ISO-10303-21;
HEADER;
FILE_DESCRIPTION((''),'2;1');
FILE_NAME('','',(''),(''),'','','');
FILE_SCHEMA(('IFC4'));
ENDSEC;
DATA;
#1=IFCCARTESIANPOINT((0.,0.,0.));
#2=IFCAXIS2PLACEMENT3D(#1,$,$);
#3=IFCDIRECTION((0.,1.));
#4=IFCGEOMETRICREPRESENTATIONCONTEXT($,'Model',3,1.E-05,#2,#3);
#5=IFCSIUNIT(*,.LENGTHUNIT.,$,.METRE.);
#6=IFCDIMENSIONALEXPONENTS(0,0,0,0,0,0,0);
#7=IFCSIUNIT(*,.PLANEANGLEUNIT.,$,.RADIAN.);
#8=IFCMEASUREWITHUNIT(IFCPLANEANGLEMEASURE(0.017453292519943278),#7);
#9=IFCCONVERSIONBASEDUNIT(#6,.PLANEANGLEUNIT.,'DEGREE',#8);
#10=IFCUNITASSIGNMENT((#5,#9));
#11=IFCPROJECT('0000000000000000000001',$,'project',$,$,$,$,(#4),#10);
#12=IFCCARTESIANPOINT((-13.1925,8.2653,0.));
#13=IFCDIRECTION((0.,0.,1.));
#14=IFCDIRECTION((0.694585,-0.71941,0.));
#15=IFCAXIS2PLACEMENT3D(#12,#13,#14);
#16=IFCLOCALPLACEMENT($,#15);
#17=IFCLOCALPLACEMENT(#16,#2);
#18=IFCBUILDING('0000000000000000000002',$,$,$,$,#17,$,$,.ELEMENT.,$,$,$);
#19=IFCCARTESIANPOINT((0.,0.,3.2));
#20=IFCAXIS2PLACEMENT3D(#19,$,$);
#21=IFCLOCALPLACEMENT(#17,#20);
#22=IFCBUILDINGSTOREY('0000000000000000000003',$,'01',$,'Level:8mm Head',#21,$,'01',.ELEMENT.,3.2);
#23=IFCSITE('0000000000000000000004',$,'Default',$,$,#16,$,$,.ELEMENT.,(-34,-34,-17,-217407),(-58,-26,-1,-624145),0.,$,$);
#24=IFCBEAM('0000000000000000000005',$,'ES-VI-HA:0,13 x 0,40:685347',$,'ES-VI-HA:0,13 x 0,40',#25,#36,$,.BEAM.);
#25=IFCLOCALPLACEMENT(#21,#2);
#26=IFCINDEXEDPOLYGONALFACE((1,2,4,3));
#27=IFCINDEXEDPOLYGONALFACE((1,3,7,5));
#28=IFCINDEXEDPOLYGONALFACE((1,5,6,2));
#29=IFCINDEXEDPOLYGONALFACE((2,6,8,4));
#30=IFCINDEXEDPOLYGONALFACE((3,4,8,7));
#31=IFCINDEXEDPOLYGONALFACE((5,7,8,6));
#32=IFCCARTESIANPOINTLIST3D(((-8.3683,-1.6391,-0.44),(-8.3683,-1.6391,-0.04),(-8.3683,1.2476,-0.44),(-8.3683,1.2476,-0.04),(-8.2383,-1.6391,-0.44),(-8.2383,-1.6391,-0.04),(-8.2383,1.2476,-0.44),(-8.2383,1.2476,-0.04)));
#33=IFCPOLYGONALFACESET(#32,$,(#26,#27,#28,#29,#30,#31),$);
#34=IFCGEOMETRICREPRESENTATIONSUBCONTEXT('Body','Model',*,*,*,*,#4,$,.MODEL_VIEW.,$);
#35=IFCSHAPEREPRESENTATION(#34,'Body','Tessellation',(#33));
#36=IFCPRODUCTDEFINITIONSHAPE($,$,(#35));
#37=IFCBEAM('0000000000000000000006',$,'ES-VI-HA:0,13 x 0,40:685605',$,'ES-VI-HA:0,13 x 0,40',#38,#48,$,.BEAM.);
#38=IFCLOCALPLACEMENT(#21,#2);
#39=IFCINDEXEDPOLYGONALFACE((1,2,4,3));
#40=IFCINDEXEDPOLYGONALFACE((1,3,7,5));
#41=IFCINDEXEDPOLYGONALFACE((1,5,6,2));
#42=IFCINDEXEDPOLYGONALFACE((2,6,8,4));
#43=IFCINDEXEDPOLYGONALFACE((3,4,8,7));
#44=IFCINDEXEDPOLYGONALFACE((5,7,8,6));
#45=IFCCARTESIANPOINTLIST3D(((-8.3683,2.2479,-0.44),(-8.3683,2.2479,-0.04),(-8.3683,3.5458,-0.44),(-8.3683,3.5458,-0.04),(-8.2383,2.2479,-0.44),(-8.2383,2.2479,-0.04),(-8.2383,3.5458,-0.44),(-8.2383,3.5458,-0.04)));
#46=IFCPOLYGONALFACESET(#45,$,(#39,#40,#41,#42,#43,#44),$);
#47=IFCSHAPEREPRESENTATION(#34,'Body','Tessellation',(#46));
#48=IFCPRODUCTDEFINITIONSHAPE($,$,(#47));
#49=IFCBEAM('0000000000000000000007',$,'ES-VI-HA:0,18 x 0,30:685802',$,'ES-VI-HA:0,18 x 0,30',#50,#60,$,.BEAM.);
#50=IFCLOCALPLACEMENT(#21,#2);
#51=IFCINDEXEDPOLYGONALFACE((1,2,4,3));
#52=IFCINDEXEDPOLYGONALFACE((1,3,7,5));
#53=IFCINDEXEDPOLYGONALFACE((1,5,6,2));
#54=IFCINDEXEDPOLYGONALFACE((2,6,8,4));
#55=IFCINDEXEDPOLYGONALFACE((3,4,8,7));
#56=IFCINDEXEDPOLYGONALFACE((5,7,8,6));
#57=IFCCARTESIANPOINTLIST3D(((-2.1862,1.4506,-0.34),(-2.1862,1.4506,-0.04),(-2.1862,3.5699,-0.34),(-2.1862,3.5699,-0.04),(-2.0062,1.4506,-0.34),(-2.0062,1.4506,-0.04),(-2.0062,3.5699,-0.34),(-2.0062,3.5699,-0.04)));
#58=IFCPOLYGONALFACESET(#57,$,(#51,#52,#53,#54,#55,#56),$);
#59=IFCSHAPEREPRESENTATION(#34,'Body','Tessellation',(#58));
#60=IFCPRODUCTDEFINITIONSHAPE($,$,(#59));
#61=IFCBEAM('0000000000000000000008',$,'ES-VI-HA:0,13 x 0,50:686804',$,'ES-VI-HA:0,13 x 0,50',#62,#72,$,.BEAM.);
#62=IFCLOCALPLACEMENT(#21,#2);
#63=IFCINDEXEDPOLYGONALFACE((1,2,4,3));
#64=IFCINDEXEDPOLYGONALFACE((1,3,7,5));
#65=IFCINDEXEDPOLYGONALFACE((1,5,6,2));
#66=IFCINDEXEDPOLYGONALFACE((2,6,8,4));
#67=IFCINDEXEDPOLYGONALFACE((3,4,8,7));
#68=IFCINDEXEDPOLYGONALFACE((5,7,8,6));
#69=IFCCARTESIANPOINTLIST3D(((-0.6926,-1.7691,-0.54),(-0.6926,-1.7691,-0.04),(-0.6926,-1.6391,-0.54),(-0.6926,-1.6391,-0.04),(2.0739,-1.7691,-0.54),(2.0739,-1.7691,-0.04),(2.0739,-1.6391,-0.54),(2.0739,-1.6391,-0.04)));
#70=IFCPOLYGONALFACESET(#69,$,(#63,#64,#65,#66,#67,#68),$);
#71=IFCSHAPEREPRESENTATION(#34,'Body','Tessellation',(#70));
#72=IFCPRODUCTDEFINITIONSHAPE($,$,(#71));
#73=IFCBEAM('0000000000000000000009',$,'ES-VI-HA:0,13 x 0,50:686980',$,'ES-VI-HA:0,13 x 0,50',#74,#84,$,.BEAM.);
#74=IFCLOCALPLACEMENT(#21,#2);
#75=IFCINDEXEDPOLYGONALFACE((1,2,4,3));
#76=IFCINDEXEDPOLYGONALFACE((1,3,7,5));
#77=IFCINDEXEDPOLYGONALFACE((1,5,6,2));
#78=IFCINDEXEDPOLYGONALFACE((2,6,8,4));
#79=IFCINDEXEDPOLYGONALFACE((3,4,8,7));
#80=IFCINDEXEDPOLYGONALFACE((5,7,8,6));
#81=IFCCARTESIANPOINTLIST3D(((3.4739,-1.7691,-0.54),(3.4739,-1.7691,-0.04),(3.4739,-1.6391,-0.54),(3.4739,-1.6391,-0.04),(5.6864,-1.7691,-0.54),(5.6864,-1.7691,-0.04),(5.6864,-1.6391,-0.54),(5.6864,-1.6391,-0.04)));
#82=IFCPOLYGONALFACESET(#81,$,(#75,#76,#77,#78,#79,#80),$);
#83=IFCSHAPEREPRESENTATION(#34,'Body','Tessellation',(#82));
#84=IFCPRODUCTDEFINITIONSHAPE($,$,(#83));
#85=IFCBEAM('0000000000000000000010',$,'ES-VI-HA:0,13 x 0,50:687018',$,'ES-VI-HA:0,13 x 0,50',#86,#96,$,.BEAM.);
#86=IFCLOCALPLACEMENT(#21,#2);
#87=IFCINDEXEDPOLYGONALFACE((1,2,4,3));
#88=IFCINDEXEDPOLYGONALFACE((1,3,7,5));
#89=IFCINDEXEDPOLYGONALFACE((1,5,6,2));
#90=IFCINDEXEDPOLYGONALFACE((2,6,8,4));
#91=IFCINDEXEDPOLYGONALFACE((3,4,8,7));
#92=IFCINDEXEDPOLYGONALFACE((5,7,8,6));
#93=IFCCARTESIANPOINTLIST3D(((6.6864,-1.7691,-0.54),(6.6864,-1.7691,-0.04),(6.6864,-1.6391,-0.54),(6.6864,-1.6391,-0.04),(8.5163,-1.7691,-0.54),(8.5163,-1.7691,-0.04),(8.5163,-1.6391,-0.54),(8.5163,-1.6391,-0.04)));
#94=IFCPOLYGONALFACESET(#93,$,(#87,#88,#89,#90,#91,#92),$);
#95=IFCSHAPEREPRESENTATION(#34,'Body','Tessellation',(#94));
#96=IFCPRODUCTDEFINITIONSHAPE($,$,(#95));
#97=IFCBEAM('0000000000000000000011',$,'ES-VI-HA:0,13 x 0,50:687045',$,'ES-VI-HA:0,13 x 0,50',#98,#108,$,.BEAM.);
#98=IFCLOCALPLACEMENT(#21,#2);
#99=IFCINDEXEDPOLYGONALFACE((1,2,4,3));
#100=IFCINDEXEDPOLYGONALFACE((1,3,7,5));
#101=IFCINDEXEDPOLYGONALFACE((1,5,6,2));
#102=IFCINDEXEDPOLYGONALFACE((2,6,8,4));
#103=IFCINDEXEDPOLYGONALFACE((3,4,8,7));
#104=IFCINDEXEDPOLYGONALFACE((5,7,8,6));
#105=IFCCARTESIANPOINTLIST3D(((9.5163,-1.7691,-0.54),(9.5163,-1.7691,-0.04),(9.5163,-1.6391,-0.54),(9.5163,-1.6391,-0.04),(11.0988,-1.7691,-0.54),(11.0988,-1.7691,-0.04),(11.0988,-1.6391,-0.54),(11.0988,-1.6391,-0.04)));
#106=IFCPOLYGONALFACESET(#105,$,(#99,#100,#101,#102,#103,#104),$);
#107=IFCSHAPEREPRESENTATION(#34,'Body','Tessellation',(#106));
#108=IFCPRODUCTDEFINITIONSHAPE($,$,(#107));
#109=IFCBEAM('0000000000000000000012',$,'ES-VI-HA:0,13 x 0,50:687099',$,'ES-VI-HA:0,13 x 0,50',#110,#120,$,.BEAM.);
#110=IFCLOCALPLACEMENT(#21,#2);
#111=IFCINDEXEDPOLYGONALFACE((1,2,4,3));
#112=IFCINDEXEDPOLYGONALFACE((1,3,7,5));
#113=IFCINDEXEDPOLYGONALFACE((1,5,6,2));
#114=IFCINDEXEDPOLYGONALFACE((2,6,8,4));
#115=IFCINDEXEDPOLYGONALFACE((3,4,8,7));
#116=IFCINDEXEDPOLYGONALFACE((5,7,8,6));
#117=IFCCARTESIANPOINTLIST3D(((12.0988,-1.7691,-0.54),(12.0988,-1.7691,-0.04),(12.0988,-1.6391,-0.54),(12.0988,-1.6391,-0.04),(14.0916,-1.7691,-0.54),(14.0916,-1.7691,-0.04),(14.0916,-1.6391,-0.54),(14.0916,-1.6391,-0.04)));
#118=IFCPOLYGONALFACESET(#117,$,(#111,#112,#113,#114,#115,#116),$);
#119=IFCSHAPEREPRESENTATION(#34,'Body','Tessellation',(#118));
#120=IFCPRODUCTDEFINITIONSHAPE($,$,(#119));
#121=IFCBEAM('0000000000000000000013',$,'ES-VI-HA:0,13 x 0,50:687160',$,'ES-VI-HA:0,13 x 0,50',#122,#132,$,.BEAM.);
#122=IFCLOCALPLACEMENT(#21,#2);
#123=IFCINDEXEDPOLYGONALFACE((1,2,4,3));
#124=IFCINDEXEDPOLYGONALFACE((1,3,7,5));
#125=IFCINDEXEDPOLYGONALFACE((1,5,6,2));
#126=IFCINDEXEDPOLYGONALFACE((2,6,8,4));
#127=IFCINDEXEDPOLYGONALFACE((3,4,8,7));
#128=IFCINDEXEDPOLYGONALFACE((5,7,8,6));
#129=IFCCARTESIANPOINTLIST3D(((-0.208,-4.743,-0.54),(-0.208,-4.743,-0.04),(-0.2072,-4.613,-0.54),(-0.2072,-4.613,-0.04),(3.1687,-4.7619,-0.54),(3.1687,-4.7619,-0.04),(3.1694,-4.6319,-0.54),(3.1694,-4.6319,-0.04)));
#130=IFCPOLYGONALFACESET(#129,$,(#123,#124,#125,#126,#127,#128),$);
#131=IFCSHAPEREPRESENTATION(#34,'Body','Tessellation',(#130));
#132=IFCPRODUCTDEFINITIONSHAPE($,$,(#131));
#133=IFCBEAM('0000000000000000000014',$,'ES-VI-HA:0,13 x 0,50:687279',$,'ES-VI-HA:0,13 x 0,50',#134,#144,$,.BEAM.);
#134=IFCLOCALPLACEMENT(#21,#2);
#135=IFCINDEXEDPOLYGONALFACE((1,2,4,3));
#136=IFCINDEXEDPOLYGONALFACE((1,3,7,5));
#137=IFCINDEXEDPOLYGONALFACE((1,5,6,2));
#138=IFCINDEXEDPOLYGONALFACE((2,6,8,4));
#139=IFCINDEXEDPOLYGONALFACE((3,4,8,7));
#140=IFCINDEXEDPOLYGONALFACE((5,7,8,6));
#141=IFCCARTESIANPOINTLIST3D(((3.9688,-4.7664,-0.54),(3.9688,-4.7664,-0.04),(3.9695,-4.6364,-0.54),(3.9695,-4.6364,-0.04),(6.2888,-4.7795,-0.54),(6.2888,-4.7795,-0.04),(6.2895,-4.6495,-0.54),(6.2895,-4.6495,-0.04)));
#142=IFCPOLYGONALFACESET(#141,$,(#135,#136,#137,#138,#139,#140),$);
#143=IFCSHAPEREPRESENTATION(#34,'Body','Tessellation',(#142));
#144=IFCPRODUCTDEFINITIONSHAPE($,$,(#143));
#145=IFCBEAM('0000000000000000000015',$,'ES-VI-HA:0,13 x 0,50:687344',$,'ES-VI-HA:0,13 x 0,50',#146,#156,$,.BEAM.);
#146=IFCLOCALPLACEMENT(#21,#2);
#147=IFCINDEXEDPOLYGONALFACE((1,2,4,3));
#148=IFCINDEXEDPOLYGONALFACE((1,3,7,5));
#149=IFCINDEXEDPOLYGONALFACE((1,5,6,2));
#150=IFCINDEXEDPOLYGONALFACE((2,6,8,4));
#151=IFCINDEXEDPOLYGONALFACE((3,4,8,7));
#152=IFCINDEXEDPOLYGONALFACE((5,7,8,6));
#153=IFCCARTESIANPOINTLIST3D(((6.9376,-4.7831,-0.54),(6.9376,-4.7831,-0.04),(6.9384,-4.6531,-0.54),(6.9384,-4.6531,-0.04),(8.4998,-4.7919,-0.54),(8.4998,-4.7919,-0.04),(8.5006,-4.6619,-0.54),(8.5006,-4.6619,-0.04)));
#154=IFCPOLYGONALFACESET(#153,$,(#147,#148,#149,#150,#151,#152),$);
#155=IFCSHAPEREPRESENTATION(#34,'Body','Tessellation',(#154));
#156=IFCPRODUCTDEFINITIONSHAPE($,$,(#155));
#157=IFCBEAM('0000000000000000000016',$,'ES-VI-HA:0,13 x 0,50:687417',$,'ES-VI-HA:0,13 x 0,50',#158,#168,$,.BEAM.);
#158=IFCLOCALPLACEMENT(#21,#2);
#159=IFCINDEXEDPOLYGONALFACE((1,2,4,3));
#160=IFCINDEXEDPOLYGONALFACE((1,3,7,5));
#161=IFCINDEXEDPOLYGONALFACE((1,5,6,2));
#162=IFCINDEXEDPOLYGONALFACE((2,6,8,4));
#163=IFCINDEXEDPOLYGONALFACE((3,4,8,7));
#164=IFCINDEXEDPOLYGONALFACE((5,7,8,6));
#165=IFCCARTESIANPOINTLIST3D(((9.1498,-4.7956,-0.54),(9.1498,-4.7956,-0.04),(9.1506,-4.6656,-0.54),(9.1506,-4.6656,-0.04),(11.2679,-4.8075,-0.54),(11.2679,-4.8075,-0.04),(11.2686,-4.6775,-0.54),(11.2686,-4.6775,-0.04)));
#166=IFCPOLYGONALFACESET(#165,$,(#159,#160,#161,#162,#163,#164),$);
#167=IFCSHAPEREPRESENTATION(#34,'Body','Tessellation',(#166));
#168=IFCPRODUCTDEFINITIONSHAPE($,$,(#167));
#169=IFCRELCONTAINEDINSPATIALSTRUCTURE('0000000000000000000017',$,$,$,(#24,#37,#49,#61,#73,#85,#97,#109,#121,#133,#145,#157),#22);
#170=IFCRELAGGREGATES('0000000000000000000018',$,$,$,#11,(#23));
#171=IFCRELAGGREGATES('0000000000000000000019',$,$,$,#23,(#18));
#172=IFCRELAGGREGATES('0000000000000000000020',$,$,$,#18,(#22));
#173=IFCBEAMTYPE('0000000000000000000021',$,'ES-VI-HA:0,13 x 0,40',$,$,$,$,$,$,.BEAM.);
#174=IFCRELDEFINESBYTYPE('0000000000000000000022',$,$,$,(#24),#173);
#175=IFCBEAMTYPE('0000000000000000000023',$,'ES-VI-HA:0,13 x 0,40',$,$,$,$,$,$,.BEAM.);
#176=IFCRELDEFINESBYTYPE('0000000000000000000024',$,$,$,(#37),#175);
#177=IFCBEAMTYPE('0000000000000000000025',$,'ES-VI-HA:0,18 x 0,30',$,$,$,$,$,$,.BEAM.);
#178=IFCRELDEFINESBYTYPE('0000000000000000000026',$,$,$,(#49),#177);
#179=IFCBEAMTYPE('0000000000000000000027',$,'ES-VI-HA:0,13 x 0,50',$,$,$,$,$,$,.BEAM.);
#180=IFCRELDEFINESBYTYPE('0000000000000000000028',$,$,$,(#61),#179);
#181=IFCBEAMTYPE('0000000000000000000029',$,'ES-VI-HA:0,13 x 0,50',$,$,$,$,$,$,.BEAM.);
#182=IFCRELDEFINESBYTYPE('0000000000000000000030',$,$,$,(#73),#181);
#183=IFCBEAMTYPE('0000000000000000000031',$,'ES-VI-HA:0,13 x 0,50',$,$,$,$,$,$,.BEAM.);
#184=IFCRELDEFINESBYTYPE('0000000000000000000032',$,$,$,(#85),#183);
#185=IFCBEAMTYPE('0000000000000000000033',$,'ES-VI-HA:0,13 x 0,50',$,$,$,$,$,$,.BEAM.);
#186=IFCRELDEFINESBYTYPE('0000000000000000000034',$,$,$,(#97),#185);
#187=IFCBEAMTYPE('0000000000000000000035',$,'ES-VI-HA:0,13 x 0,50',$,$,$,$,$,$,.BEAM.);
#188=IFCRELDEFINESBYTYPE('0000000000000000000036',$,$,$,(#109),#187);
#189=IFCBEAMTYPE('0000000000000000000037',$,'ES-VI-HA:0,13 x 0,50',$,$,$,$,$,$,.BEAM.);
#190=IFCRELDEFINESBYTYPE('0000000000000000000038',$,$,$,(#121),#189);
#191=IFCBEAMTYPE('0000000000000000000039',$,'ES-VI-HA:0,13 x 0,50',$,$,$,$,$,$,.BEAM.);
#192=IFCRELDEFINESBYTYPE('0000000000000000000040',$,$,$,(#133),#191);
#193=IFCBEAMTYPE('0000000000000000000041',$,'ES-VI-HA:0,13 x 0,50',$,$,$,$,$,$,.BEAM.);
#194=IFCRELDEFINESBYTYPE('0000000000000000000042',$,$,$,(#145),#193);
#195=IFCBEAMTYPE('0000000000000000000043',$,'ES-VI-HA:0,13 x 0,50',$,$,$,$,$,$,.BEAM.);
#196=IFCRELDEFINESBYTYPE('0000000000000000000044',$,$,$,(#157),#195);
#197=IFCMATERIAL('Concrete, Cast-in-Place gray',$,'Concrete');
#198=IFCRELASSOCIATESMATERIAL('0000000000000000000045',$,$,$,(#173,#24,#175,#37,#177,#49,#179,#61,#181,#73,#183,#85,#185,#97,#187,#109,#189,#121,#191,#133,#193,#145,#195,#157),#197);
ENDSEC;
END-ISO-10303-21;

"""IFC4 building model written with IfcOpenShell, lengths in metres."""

from ifc_helpers import new_model, entity, si_unit, converted_unit, direction, frame, origin, place, context, subcontext, project, spatial, indexed_curve, outline, extrude, source, transform, mapped, material, type_object, type_shapes, element, save


model = new_model("IFC4")

# Units and contexts
model_context = context("Model", 3, precision=1e-05, world=origin(), true_north=direction((0.0, 1.0)))
body_context = subcontext(model_context, "Body", "Model", "MODEL_VIEW")
ifc_project = project(units=[si_unit("LENGTHUNIT", "METRE"), converted_unit("PLANEANGLEUNIT", "DEGREE", entity("IfcPlaneAngleMeasure", 0.017453292519943278), si_unit("PLANEANGLEUNIT", "RADIAN"), dimensions=[0, 0, 0, 0, 0, 0, 0])], contexts=[model_context])

# Site, building, storey
site_placement = place(None, frame((-13.1925, 8.2653, 0.0), z_axis=(0.0, 0.0, 1.0), x_axis=(0.694585, -0.71941, 0.0)))
site = spatial("IfcSite", under=ifc_project, at=site_placement, Name="Default", CompositionType="ELEMENT", RefLatitude=(-34, -34, -17, -217407), RefLongitude=(-58, -26, -1, -624145), RefElevation=0.0)
building_placement = place(site_placement, origin())
building = spatial("IfcBuilding", under=site, at=building_placement, CompositionType="ELEMENT")
storey_placement = place(building_placement, frame((0.0, 0.0, 3.2)))
storey = spatial("IfcBuildingStorey", under=building, at=storey_placement, Name="01", ObjectType="Level:8mm Head", LongName="01", CompositionType="ELEMENT", Elevation=3.2)

# Beams
ifc_material_1 = material(Name="Concrete, Cast-in-Place gray", Category="Concrete")
beam_type_1 = type_object("IfcBeamType", Name="ES-VI-HA:0,13 x 0,40", PredefinedType="BEAM", material=ifc_material_1)
shared_shape_1 = source(origin(), body_context, "Body", "SweptSolid", [
    extrude(outline(indexed_curve([(-0.065, -0.2), (0.065, -0.2), (0.065, 0.2), (-0.065, 0.2), (-0.065, -0.2)], self_intersect=False)), frame((-8.3033, -1.6391, 2.96), z_axis=(0.0, 1.0, 0.0), x_axis=(-1.0, 0.0, 0.0)), (0.0, 0.0, 1.0), 2.8867),
])
type_shapes(beam_type_1, [shared_shape_1])
beam_1_placement = place(storey_placement, frame((0.0, 0.0, -3.2)))
element("IfcBeam", 1, at=beam_1_placement, inside=storey, type_object=beam_type_1, material=ifc_material_1, Name="ES-VI-HA:0,13 x 0,40:685347", ObjectType="ES-VI-HA:0,13 x 0,40", PredefinedType="BEAM", context=body_context, shape_type="MappedRepresentation", body=[
    mapped(shared_shape_1, transform((0.0, 0.0, 0.0), scale=1.0)),
])
beam_type_2 = type_object("IfcBeamType", Name="ES-VI-HA:0,13 x 0,40", PredefinedType="BEAM", material=ifc_material_1)
shared_shape_2 = source(origin(), body_context, "Body", "SweptSolid", [
    extrude(outline(indexed_curve([(-0.065, -0.2), (0.065, -0.2), (0.065, 0.2), (-0.065, 0.2), (-0.065, -0.2)], self_intersect=False)), frame((-8.3033, 2.2479, 2.96), z_axis=(0.0, 1.0, 0.0), x_axis=(-1.0, 0.0, 0.0)), (0.0, 0.0, 1.0), 1.298),
])
type_shapes(beam_type_2, [shared_shape_2])
beam_2_placement = place(storey_placement, frame((0.0, 0.0, -3.2)))
element("IfcBeam", 2, at=beam_2_placement, inside=storey, type_object=beam_type_2, material=ifc_material_1, Name="ES-VI-HA:0,13 x 0,40:685605", ObjectType="ES-VI-HA:0,13 x 0,40", PredefinedType="BEAM", context=body_context, shape_type="MappedRepresentation", body=[
    mapped(shared_shape_2, transform((0.0, 0.0, 0.0), scale=1.0)),
])
beam_type_3 = type_object("IfcBeamType", Name="ES-VI-HA:0,18 x 0,30", PredefinedType="BEAM", material=ifc_material_1)
shared_shape_3 = source(origin(), body_context, "Body", "SweptSolid", [
    extrude(outline(indexed_curve([(-0.09, -0.15), (0.09, -0.15), (0.09, 0.15), (-0.09, 0.15), (-0.09, -0.15)], self_intersect=False)), frame((-2.0962, 3.5699, 3.01), z_axis=(0.0, -1.0, 0.0), x_axis=(-1.0, 0.0, 0.0)), (0.0, 0.0, 1.0), 2.1193),
])
type_shapes(beam_type_3, [shared_shape_3])
beam_3_placement = place(storey_placement, frame((0.0, 0.0, -3.2)))
element("IfcBeam", 3, at=beam_3_placement, inside=storey, type_object=beam_type_3, material=ifc_material_1, Name="ES-VI-HA:0,18 x 0,30:685802", ObjectType="ES-VI-HA:0,18 x 0,30", PredefinedType="BEAM", context=body_context, shape_type="MappedRepresentation", body=[
    mapped(shared_shape_3, transform((0.0, 0.0, 0.0), scale=1.0)),
])
beam_type_4 = type_object("IfcBeamType", Name="ES-VI-HA:0,13 x 0,50", PredefinedType="BEAM", material=ifc_material_1)
shared_shape_4 = source(origin(), body_context, "Body", "SweptSolid", [
    extrude(outline(indexed_curve([(-0.25, -0.065), (0.25, -0.065), (0.25, 0.065), (-0.25, 0.065), (-0.25, -0.065)], self_intersect=False)), frame((-0.6926, -1.7041, 2.91), z_axis=(1.0, 0.0, 0.0), x_axis=(0.0, 0.0, -1.0)), (0.0, 0.0, 1.0), 2.7665),
])
type_shapes(beam_type_4, [shared_shape_4])
beam_4_placement = place(storey_placement, frame((0.0, 0.0, -3.2)))
element("IfcBeam", 4, at=beam_4_placement, inside=storey, type_object=beam_type_4, material=ifc_material_1, Name="ES-VI-HA:0,13 x 0,50:686804", ObjectType="ES-VI-HA:0,13 x 0,50", PredefinedType="BEAM", context=body_context, shape_type="MappedRepresentation", body=[
    mapped(shared_shape_4, transform((0.0, 0.0, 0.0), scale=1.0)),
])
beam_type_5 = type_object("IfcBeamType", Name="ES-VI-HA:0,13 x 0,50", PredefinedType="BEAM", material=ifc_material_1)
shared_shape_5 = source(origin(), body_context, "Body", "SweptSolid", [
    extrude(outline(indexed_curve([(-0.25, -0.065), (0.25, -0.065), (0.25, 0.065), (-0.25, 0.065), (-0.25, -0.065)], self_intersect=False)), frame((3.4739, -1.7041, 2.91), z_axis=(1.0, 0.0, 0.0), x_axis=(0.0, 0.0, -1.0)), (0.0, 0.0, 1.0), 2.2125),
])
type_shapes(beam_type_5, [shared_shape_5])
beam_5_placement = place(storey_placement, frame((0.0, 0.0, -3.2)))
element("IfcBeam", 5, at=beam_5_placement, inside=storey, type_object=beam_type_5, material=ifc_material_1, Name="ES-VI-HA:0,13 x 0,50:686980", ObjectType="ES-VI-HA:0,13 x 0,50", PredefinedType="BEAM", context=body_context, shape_type="MappedRepresentation", body=[
    mapped(shared_shape_5, transform((0.0, 0.0, 0.0), scale=1.0)),
])
beam_type_6 = type_object("IfcBeamType", Name="ES-VI-HA:0,13 x 0,50", PredefinedType="BEAM", material=ifc_material_1)
shared_shape_6 = source(origin(), body_context, "Body", "SweptSolid", [
    extrude(outline(indexed_curve([(-0.25, -0.065), (0.25, -0.065), (0.25, 0.065), (-0.25, 0.065), (-0.25, -0.065)], self_intersect=False)), frame((6.6864, -1.7041, 2.91), z_axis=(1.0, 0.0, 0.0), x_axis=(0.0, 0.0, -1.0)), (0.0, 0.0, 1.0), 1.8299),
])
type_shapes(beam_type_6, [shared_shape_6])
beam_6_placement = place(storey_placement, frame((0.0, 0.0, -3.2)))
element("IfcBeam", 6, at=beam_6_placement, inside=storey, type_object=beam_type_6, material=ifc_material_1, Name="ES-VI-HA:0,13 x 0,50:687018", ObjectType="ES-VI-HA:0,13 x 0,50", PredefinedType="BEAM", context=body_context, shape_type="MappedRepresentation", body=[
    mapped(shared_shape_6, transform((0.0, 0.0, 0.0), scale=1.0)),
])
beam_type_7 = type_object("IfcBeamType", Name="ES-VI-HA:0,13 x 0,50", PredefinedType="BEAM", material=ifc_material_1)
shared_shape_7 = source(origin(), body_context, "Body", "SweptSolid", [
    extrude(outline(indexed_curve([(-0.25, -0.065), (0.25, -0.065), (0.25, 0.065), (-0.25, 0.065), (-0.25, -0.065)], self_intersect=False)), frame((9.5163, -1.7041, 2.91), z_axis=(1.0, 0.0, 0.0), x_axis=(0.0, 0.0, -1.0)), (0.0, 0.0, 1.0), 1.5825),
])
type_shapes(beam_type_7, [shared_shape_7])
beam_7_placement = place(storey_placement, frame((0.0, 0.0, -3.2)))
element("IfcBeam", 7, at=beam_7_placement, inside=storey, type_object=beam_type_7, material=ifc_material_1, Name="ES-VI-HA:0,13 x 0,50:687045", ObjectType="ES-VI-HA:0,13 x 0,50", PredefinedType="BEAM", context=body_context, shape_type="MappedRepresentation", body=[
    mapped(shared_shape_7, transform((0.0, 0.0, 0.0), scale=1.0)),
])
beam_type_8 = type_object("IfcBeamType", Name="ES-VI-HA:0,13 x 0,50", PredefinedType="BEAM", material=ifc_material_1)
shared_shape_8 = source(origin(), body_context, "Body", "SweptSolid", [
    extrude(outline(indexed_curve([(-0.25, -0.065), (0.25, -0.065), (0.25, 0.065), (-0.25, 0.065), (-0.25, -0.065)], self_intersect=False)), frame((12.0988, -1.7041, 2.91), z_axis=(1.0, 0.0, 0.0), x_axis=(0.0, 0.0, -1.0)), (0.0, 0.0, 1.0), 1.9928),
])
type_shapes(beam_type_8, [shared_shape_8])
beam_8_placement = place(storey_placement, frame((0.0, 0.0, -3.2)))
element("IfcBeam", 8, at=beam_8_placement, inside=storey, type_object=beam_type_8, material=ifc_material_1, Name="ES-VI-HA:0,13 x 0,50:687099", ObjectType="ES-VI-HA:0,13 x 0,50", PredefinedType="BEAM", context=body_context, shape_type="MappedRepresentation", body=[
    mapped(shared_shape_8, transform((0.0, 0.0, 0.0), scale=1.0)),
])
beam_type_9 = type_object("IfcBeamType", Name="ES-VI-HA:0,13 x 0,50", PredefinedType="BEAM", material=ifc_material_1)
shared_shape_9 = source(origin(), body_context, "Body", "SweptSolid", [
    extrude(outline(indexed_curve([(-0.25, -0.065), (0.25, -0.065), (0.25, 0.065), (-0.25, 0.065), (-0.25, -0.065)], self_intersect=False)), frame((-0.2076, -4.678, 2.91), z_axis=(0.999984, -0.005619, 0.0), x_axis=(0.0, 0.0, -1.0)), (0.0, 0.0, 1.0), 3.3767),
])
type_shapes(beam_type_9, [shared_shape_9])
beam_9_placement = place(storey_placement, frame((0.0, 0.0, -3.2)))
element("IfcBeam", 9, at=beam_9_placement, inside=storey, type_object=beam_type_9, material=ifc_material_1, Name="ES-VI-HA:0,13 x 0,50:687160", ObjectType="ES-VI-HA:0,13 x 0,50", PredefinedType="BEAM", context=body_context, shape_type="MappedRepresentation", body=[
    mapped(shared_shape_9, transform((0.0, 0.0, 0.0), scale=1.0)),
])
beam_type_10 = type_object("IfcBeamType", Name="ES-VI-HA:0,13 x 0,50", PredefinedType="BEAM", material=ifc_material_1)
shared_shape_10 = source(origin(), body_context, "Body", "SweptSolid", [
    extrude(outline(indexed_curve([(-0.25, -0.065), (0.25, -0.065), (0.25, 0.065), (-0.25, 0.065), (-0.25, -0.065)], self_intersect=False)), frame((3.9692, -4.7014, 2.91), z_axis=(0.999984, -0.005619, 0.0), x_axis=(0.0, 0.0, -1.0)), (0.0, 0.0, 1.0), 2.32),
])
type_shapes(beam_type_10, [shared_shape_10])
beam_10_placement = place(storey_placement, frame((0.0, 0.0, -3.2)))
element("IfcBeam", 10, at=beam_10_placement, inside=storey, type_object=beam_type_10, material=ifc_material_1, Name="ES-VI-HA:0,13 x 0,50:687279", ObjectType="ES-VI-HA:0,13 x 0,50", PredefinedType="BEAM", context=body_context, shape_type="MappedRepresentation", body=[
    mapped(shared_shape_10, transform((0.0, 0.0, 0.0), scale=1.0)),
])
beam_type_11 = type_object("IfcBeamType", Name="ES-VI-HA:0,13 x 0,50", PredefinedType="BEAM", material=ifc_material_1)
shared_shape_11 = source(origin(), body_context, "Body", "SweptSolid", [
    extrude(outline(indexed_curve([(-0.25, -0.065), (0.25, -0.065), (0.25, 0.065), (-0.25, 0.065), (-0.25, -0.065)], self_intersect=False)), frame((6.938, -4.7181, 2.91), z_axis=(0.999984, -0.005619, 0.0), x_axis=(0.0, 0.0, -1.0)), (0.0, 0.0, 1.0), 1.5622),
])
type_shapes(beam_type_11, [shared_shape_11])
beam_11_placement = place(storey_placement, frame((0.0, 0.0, -3.2)))
element("IfcBeam", 11, at=beam_11_placement, inside=storey, type_object=beam_type_11, material=ifc_material_1, Name="ES-VI-HA:0,13 x 0,50:687344", ObjectType="ES-VI-HA:0,13 x 0,50", PredefinedType="BEAM", context=body_context, shape_type="MappedRepresentation", body=[
    mapped(shared_shape_11, transform((0.0, 0.0, 0.0), scale=1.0)),
])
beam_type_12 = type_object("IfcBeamType", Name="ES-VI-HA:0,13 x 0,50", PredefinedType="BEAM", material=ifc_material_1)
shared_shape_12 = source(origin(), body_context, "Body", "SweptSolid", [
    extrude(outline(indexed_curve([(-0.25, -0.065), (0.25, -0.065), (0.25, 0.065), (-0.25, 0.065), (-0.25, -0.065)], self_intersect=False)), frame((9.1502, -4.7306, 2.91), z_axis=(0.999984, -0.005619, 0.0), x_axis=(0.0, 0.0, -1.0)), (0.0, 0.0, 1.0), 2.1181),
])
type_shapes(beam_type_12, [shared_shape_12])
beam_12_placement = place(storey_placement, frame((0.0, 0.0, -3.2)))
element("IfcBeam", 12, at=beam_12_placement, inside=storey, type_object=beam_type_12, material=ifc_material_1, Name="ES-VI-HA:0,13 x 0,50:687417", ObjectType="ES-VI-HA:0,13 x 0,50", PredefinedType="BEAM", context=body_context, shape_type="MappedRepresentation", body=[
    mapped(shared_shape_12, transform((0.0, 0.0, 0.0), scale=1.0)),
])

save(model, "model.ifc")
